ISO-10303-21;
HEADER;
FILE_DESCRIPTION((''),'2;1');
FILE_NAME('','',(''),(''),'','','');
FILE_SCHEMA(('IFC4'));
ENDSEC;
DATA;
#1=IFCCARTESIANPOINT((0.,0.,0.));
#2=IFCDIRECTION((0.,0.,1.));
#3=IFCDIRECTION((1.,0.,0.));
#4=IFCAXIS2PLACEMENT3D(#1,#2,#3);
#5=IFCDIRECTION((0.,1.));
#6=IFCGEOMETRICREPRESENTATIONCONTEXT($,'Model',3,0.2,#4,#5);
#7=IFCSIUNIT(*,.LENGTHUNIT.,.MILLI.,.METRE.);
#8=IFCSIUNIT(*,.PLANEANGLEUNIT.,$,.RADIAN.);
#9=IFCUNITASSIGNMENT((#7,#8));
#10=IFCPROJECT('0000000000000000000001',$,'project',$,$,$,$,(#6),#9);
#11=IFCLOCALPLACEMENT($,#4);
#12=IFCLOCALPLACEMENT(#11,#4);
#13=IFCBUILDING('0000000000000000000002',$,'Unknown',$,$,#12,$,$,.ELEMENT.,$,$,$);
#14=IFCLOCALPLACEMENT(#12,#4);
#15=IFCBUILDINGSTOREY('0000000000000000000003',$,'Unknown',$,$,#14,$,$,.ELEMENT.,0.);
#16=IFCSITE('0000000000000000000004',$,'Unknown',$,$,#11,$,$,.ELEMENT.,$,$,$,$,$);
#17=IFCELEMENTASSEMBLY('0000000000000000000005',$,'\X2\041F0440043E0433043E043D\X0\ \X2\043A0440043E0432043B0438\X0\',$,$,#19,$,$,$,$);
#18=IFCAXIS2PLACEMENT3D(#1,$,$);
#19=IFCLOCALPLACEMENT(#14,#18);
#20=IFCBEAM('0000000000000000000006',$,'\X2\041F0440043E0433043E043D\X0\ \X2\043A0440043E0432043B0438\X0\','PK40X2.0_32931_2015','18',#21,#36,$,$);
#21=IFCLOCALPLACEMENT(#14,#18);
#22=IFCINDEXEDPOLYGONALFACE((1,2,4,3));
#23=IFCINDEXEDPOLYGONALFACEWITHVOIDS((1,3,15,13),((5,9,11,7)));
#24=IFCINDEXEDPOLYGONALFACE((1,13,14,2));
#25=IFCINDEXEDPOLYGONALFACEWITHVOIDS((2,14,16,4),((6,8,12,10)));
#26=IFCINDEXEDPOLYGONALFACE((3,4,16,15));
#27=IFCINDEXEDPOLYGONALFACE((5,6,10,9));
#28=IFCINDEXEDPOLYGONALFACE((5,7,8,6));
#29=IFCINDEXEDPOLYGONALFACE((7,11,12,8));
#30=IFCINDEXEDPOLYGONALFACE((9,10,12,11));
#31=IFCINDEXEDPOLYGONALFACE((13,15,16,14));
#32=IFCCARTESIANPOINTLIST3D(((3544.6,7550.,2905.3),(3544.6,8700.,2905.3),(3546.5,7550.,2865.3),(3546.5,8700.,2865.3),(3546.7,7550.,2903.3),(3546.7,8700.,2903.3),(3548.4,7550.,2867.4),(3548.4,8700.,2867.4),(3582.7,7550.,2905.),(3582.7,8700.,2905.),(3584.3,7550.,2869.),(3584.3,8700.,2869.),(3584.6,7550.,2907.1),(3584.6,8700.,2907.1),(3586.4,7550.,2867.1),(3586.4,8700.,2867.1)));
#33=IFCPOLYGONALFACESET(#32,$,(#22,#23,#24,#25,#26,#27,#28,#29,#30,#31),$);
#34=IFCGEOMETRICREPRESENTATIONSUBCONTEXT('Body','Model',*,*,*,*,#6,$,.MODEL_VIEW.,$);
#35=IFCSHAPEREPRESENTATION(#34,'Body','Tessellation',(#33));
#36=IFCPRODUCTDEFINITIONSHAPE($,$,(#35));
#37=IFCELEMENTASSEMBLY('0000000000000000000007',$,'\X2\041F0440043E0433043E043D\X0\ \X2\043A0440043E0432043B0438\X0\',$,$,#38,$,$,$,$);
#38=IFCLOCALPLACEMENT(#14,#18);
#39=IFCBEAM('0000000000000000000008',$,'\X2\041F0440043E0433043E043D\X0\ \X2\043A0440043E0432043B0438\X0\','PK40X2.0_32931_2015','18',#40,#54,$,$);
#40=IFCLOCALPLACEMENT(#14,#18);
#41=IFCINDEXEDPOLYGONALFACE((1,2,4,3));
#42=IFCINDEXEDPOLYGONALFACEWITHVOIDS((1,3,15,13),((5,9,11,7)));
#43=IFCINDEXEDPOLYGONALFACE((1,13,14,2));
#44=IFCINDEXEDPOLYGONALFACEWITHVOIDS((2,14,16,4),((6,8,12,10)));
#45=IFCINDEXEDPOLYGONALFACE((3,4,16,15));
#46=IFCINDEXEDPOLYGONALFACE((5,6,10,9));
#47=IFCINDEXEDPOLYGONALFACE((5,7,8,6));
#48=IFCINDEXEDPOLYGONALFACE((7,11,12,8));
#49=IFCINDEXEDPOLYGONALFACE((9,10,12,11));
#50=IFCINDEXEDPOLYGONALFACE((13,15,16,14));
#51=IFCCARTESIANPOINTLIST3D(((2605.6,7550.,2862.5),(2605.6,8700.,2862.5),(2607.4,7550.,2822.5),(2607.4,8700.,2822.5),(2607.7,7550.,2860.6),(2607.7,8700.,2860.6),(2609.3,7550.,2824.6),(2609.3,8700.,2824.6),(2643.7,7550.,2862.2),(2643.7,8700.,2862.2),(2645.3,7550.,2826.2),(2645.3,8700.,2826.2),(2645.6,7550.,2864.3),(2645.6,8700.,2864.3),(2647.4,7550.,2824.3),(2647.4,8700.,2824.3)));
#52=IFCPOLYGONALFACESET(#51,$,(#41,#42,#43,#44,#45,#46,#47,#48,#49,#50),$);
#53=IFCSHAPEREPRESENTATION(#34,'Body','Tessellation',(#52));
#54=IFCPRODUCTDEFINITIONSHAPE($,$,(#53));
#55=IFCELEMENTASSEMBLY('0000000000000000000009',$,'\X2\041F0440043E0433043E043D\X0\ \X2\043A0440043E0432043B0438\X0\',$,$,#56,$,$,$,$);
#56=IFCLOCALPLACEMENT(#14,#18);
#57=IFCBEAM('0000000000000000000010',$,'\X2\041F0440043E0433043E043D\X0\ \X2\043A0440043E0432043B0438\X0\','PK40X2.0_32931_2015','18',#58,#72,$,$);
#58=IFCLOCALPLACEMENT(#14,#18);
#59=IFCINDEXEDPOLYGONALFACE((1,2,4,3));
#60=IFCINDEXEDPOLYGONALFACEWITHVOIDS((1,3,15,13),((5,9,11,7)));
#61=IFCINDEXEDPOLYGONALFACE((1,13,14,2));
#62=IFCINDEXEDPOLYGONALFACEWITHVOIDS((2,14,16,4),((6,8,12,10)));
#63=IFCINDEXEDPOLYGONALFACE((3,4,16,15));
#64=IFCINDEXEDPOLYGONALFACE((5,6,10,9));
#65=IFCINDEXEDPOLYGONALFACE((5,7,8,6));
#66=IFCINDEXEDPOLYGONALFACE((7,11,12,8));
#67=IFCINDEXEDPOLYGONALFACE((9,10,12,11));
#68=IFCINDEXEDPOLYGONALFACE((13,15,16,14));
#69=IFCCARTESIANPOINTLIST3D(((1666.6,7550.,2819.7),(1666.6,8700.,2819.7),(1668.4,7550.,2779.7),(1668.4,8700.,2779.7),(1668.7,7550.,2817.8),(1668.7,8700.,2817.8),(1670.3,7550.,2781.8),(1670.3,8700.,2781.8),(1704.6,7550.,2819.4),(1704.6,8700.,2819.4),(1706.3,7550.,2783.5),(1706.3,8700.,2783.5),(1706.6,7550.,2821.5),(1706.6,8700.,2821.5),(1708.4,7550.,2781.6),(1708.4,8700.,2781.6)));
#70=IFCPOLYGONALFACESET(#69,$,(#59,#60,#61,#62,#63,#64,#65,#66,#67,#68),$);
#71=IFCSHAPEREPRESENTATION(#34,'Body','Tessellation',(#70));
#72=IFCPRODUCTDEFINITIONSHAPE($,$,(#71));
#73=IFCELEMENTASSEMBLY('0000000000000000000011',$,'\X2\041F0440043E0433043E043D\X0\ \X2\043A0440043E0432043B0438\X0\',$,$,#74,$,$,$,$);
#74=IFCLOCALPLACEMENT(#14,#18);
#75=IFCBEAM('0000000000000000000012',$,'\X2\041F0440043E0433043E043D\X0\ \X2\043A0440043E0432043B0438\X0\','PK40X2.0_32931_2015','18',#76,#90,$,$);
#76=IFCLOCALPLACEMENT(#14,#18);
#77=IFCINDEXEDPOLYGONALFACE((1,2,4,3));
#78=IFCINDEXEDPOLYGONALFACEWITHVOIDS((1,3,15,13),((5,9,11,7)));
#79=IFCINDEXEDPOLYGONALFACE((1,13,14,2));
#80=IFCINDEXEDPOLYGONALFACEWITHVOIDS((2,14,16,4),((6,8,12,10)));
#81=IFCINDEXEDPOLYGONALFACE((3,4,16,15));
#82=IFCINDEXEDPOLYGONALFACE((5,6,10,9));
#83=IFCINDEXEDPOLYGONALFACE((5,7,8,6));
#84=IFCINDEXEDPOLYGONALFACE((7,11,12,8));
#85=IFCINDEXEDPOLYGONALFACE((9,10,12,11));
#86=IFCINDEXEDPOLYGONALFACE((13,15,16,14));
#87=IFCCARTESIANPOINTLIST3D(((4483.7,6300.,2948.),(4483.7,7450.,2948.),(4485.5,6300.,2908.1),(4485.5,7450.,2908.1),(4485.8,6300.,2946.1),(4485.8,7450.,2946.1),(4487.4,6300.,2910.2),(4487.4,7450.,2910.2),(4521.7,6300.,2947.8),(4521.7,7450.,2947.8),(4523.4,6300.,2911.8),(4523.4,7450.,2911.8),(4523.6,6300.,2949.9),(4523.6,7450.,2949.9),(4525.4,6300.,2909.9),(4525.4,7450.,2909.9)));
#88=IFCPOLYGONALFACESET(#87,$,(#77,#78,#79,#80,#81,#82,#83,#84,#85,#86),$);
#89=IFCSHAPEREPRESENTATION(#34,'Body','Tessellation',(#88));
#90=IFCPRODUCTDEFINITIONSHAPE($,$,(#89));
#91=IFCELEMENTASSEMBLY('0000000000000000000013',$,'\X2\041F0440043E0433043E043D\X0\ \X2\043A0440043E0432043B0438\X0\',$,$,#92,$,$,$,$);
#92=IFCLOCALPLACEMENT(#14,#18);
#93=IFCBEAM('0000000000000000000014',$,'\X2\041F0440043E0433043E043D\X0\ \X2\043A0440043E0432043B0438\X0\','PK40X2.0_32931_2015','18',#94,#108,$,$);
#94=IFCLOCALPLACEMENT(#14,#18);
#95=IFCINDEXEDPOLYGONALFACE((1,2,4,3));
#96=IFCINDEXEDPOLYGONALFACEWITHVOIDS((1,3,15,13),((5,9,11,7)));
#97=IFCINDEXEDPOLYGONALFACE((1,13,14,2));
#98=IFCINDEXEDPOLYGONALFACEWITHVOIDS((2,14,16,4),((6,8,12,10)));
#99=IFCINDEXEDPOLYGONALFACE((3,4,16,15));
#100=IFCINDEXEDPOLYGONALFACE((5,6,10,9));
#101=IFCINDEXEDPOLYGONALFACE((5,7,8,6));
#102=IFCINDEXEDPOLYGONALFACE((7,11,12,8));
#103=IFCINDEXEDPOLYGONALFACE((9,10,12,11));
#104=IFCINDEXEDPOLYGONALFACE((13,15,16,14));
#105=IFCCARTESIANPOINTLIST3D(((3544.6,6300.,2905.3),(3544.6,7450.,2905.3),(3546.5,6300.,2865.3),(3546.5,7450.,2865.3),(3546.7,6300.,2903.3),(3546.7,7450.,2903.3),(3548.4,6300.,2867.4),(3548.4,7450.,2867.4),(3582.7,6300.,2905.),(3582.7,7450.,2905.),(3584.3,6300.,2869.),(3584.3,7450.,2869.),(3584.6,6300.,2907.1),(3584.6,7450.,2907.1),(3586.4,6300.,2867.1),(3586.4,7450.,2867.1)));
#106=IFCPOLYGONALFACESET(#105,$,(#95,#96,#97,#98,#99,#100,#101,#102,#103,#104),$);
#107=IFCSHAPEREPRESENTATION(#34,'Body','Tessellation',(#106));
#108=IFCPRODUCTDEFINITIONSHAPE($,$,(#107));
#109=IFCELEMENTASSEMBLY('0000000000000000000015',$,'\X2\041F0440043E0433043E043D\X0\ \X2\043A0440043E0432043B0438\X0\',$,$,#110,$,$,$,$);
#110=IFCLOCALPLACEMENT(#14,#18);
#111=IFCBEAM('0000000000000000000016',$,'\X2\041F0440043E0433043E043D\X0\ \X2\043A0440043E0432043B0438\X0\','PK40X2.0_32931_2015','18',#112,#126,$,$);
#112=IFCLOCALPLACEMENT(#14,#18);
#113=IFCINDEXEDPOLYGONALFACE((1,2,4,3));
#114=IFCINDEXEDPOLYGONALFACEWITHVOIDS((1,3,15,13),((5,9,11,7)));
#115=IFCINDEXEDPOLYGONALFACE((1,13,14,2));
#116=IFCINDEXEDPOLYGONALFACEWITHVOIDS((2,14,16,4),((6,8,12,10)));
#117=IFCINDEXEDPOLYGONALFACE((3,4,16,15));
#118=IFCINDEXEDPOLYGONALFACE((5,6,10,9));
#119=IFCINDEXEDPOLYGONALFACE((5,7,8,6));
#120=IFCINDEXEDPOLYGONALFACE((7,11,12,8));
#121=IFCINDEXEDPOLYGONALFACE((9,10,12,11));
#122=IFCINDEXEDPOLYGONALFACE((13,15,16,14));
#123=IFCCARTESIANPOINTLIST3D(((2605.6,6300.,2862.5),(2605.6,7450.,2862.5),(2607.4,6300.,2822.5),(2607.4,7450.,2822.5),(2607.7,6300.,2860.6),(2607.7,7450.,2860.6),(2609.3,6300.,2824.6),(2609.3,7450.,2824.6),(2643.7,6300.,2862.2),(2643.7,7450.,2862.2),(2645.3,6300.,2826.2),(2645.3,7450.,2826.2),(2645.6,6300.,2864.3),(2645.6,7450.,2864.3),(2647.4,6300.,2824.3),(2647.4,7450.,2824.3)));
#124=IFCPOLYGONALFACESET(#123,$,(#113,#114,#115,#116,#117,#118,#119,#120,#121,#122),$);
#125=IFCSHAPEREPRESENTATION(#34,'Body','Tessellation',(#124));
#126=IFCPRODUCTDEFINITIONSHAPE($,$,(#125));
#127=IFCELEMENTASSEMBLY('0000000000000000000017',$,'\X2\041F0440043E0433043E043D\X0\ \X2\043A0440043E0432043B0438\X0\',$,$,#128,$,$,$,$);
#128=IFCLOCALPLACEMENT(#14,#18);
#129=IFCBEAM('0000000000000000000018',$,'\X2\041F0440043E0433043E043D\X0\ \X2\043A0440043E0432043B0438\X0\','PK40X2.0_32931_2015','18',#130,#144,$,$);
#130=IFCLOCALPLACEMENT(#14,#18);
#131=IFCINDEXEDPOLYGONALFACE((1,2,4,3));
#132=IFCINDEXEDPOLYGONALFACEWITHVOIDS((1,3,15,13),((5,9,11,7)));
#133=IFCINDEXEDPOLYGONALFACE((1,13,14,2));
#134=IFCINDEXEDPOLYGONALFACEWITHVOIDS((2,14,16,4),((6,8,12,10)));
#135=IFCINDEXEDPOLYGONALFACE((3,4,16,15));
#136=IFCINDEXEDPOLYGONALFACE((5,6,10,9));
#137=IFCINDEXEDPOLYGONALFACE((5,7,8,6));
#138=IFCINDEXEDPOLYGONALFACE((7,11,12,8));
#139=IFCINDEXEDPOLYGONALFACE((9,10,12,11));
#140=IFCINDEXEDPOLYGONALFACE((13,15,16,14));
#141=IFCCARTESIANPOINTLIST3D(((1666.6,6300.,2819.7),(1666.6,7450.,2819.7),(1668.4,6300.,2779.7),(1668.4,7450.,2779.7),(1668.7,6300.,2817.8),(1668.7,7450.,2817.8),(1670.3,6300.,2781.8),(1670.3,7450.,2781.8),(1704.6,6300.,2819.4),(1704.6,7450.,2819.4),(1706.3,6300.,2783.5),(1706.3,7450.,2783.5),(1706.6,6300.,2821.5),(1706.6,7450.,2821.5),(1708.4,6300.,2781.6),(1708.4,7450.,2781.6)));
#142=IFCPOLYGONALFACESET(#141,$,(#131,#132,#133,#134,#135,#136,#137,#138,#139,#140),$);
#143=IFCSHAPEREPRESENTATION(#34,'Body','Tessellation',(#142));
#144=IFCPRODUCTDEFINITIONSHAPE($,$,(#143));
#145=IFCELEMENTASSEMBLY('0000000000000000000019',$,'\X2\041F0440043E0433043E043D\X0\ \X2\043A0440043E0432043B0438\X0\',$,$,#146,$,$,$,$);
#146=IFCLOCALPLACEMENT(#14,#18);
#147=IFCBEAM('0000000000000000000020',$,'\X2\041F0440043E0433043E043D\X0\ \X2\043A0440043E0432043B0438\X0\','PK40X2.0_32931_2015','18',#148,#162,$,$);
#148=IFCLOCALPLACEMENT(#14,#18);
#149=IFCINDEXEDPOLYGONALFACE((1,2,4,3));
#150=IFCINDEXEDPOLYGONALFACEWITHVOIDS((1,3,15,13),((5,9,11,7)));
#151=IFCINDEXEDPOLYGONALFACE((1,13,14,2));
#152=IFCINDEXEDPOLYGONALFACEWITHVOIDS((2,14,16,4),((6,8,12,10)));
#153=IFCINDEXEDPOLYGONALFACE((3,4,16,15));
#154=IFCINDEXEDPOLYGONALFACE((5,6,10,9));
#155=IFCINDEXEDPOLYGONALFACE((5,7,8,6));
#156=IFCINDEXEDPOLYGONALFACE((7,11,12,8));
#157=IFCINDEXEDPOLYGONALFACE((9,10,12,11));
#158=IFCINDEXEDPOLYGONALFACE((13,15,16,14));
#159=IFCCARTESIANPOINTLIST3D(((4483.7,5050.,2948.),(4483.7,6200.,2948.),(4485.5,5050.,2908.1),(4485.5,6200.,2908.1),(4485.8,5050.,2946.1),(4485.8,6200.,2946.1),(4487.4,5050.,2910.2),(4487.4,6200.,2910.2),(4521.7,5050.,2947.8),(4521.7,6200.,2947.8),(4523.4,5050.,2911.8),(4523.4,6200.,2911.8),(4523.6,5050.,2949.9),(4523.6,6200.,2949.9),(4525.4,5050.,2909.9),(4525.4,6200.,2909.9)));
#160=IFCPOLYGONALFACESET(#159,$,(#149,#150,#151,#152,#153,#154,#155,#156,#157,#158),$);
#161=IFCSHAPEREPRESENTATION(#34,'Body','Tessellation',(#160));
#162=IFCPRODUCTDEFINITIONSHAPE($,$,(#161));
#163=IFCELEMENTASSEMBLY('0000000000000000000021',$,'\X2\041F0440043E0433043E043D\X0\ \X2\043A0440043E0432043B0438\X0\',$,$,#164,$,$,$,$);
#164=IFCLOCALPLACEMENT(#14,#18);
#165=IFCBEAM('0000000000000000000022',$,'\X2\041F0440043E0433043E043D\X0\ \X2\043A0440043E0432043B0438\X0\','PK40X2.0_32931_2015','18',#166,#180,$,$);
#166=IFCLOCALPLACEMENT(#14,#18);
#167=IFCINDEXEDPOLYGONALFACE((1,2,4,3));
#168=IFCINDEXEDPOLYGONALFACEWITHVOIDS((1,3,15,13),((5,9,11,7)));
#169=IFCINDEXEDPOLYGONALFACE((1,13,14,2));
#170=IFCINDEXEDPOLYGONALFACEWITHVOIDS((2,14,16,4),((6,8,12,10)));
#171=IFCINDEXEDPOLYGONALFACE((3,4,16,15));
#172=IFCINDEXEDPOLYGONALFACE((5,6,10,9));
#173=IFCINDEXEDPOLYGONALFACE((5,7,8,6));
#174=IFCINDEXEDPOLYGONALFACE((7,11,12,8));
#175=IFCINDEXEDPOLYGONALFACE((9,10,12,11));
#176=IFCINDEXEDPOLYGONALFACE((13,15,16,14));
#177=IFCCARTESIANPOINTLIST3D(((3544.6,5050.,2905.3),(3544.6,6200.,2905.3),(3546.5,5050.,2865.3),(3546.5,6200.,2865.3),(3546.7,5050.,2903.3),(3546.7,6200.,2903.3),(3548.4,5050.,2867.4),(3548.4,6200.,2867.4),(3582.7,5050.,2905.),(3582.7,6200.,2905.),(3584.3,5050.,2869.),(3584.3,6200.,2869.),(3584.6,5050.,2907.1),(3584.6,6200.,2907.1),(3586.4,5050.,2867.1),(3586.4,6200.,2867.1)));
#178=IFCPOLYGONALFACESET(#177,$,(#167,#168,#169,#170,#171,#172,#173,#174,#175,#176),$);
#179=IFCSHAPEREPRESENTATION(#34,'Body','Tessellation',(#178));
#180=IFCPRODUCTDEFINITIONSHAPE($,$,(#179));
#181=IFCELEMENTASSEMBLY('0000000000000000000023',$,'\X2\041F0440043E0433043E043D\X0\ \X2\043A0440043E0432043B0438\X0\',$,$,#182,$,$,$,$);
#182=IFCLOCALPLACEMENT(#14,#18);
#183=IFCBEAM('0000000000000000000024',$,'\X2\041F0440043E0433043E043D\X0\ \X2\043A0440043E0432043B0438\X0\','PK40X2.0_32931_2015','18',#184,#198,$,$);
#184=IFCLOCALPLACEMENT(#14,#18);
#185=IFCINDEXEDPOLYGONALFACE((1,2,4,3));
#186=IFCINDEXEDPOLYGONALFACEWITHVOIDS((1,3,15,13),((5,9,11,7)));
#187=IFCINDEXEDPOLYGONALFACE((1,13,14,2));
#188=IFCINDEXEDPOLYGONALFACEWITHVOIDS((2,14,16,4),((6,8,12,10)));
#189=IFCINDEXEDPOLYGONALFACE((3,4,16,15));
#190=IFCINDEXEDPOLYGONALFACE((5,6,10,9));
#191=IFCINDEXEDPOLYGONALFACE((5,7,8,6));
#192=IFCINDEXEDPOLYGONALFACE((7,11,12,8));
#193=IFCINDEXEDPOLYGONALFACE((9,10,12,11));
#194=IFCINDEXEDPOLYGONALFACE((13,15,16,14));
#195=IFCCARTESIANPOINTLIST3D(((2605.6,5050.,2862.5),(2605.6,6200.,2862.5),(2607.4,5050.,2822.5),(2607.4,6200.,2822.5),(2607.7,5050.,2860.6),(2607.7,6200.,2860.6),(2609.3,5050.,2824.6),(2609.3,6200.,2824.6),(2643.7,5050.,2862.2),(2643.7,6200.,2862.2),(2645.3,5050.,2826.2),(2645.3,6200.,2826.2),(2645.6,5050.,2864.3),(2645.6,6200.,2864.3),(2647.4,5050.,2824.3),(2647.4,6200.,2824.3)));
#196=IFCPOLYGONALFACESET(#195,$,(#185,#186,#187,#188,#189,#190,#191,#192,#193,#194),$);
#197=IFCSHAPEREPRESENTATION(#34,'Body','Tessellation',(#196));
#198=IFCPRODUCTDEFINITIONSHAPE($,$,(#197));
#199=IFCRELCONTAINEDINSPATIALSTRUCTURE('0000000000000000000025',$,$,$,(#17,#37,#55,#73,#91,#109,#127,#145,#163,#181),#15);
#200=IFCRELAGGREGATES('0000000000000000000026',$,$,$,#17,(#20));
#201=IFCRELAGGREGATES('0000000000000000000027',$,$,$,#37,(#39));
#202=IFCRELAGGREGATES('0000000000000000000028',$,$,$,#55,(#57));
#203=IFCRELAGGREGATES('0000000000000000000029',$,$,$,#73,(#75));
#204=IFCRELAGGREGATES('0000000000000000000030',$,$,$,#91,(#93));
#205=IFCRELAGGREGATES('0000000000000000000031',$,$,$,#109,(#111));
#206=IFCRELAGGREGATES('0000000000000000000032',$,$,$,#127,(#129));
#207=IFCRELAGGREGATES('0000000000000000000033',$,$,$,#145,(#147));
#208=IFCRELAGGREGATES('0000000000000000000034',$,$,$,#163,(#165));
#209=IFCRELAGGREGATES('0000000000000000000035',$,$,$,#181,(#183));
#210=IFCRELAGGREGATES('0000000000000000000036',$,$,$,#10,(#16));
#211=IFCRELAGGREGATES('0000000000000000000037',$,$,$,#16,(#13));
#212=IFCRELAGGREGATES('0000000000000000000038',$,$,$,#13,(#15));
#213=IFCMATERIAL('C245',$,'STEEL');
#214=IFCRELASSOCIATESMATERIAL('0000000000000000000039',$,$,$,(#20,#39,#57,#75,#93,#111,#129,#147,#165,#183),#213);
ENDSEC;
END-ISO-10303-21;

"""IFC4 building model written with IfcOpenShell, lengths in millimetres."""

from ifc_helpers import new_model, si_unit, direction, frame, origin_with_axes, place, context, subcontext, project, spatial, line, indexed_curve, outline, extrude, material, element, aggregate, save


model = new_model("IFC4")

# Units and contexts
model_context = context("Model", 3, precision=0.2, world=origin_with_axes(), true_north=direction((0.0, 1.0)))
body_context = subcontext(model_context, "Body", "Model", "MODEL_VIEW")
ifc_project = project(units=[si_unit("LENGTHUNIT", "METRE", prefix="MILLI"), si_unit("PLANEANGLEUNIT", "RADIAN")], contexts=[model_context])

# Site, building, storey
site_placement = place(None, origin_with_axes())
site = spatial("IfcSite", under=ifc_project, at=site_placement, Name="Unknown", CompositionType="ELEMENT")
building_placement = place(site_placement, origin_with_axes())
building = spatial("IfcBuilding", under=site, at=building_placement, Name="Unknown", CompositionType="ELEMENT")
storey_placement = place(building_placement, origin_with_axes())
storey = spatial("IfcBuildingStorey", under=building, at=storey_placement, Name="Unknown", CompositionType="ELEMENT", Elevation=0.0)

# Shared definitions
ifc_material_1 = material(Name="C245", Category="STEEL")

# Element assemblies, beams
assembly_1_placement = place(storey_placement, frame((3565.5, 8700.0, 2886.2), z_axis=(-0.998964, 0.0, -0.045508), x_axis=(0.0, -1.0, 0.0)))
assembly_1 = element("IfcElementAssembly", 1, at=assembly_1_placement, inside=storey, Name="Прогон кровли")
beam_1_placement = place(assembly_1_placement, origin_with_axes())
beam_1 = element("IfcBeam", 2, at=beam_1_placement, material=ifc_material_1, Name="Прогон кровли", Description="PK40X2.0_32931_2015", ObjectType="18", context=body_context, shape_type="SolidModel", body=[
    extrude(outline(indexed_curve([(-20.0, -20.0), (20.0, -20.0), (20.0, 20.0), (-20.0, 20.0)], segments=[line(1, 2, 3, 4, 1)]), holes=[indexed_curve([(-18.0, -18.0), (-18.0, 18.0), (18.0, 18.0), (18.0, -18.0)], segments=[line(1, 2, 3, 4, 1)])]), frame((0.0, 0.0, 0.0), z_axis=(-1.0, 0.0, 0.0), x_axis=(0.0, 0.0, 1.0)), (0.0, 0.0, -1.0), 1150.0),
])
aggregate(assembly_1, [beam_1])
assembly_2_placement = place(storey_placement, frame((2626.5, 8700.0, 2843.4), z_axis=(-0.998964, 0.0, -0.045508), x_axis=(0.0, -1.0, 0.0)))
assembly_2 = element("IfcElementAssembly", 3, at=assembly_2_placement, inside=storey, Name="Прогон кровли")
beam_2_placement = place(assembly_2_placement, origin_with_axes())
beam_2 = element("IfcBeam", 4, at=beam_2_placement, material=ifc_material_1, Name="Прогон кровли", Description="PK40X2.0_32931_2015", ObjectType="18", context=body_context, shape_type="SolidModel", body=[
    extrude(outline(indexed_curve([(-20.0, -20.0), (20.0, -20.0), (20.0, 20.0), (-20.0, 20.0)], segments=[line(1, 2, 3, 4, 1)]), holes=[indexed_curve([(-18.0, -18.0), (-18.0, 18.0), (18.0, 18.0), (18.0, -18.0)], segments=[line(1, 2, 3, 4, 1)])]), frame((0.0, 0.0, 0.0), z_axis=(-1.0, 0.0, 0.0), x_axis=(0.0, 0.0, 1.0)), (0.0, 0.0, -1.0), 1150.0),
])
aggregate(assembly_2, [beam_2])
assembly_3_placement = place(storey_placement, frame((1687.5, 8700.0, 2800.6), z_axis=(-0.998964, 0.0, -0.045508), x_axis=(0.0, -1.0, 0.0)))
assembly_3 = element("IfcElementAssembly", 5, at=assembly_3_placement, inside=storey, Name="Прогон кровли")
beam_3_placement = place(assembly_3_placement, origin_with_axes())
beam_3 = element("IfcBeam", 6, at=beam_3_placement, material=ifc_material_1, Name="Прогон кровли", Description="PK40X2.0_32931_2015", ObjectType="18", context=body_context, shape_type="SolidModel", body=[
    extrude(outline(indexed_curve([(-20.0, -20.0), (20.0, -20.0), (20.0, 20.0), (-20.0, 20.0)], segments=[line(1, 2, 3, 4, 1)]), holes=[indexed_curve([(-18.0, -18.0), (-18.0, 18.0), (18.0, 18.0), (18.0, -18.0)], segments=[line(1, 2, 3, 4, 1)])]), frame((0.0, 0.0, 0.0), z_axis=(-1.0, 0.0, 0.0), x_axis=(0.0, 0.0, 1.0)), (0.0, 0.0, -1.0), 1150.0),
])
aggregate(assembly_3, [beam_3])
assembly_4_placement = place(storey_placement, frame((4504.6, 7450.0, 2929.0), z_axis=(-0.998964, 0.0, -0.045508), x_axis=(0.0, -1.0, 0.0)))
assembly_4 = element("IfcElementAssembly", 7, at=assembly_4_placement, inside=storey, Name="Прогон кровли")
beam_4_placement = place(assembly_4_placement, origin_with_axes())
beam_4 = element("IfcBeam", 8, at=beam_4_placement, material=ifc_material_1, Name="Прогон кровли", Description="PK40X2.0_32931_2015", ObjectType="18", context=body_context, shape_type="SolidModel", body=[
    extrude(outline(indexed_curve([(-20.0, -20.0), (20.0, -20.0), (20.0, 20.0), (-20.0, 20.0)], segments=[line(1, 2, 3, 4, 1)]), holes=[indexed_curve([(-18.0, -18.0), (-18.0, 18.0), (18.0, 18.0), (18.0, -18.0)], segments=[line(1, 2, 3, 4, 1)])]), frame((0.0, 0.0, 0.0), z_axis=(-1.0, 0.0, 0.0), x_axis=(0.0, 0.0, 1.0)), (0.0, 0.0, -1.0), 1150.0),
])
aggregate(assembly_4, [beam_4])
assembly_5_placement = place(storey_placement, frame((3565.5, 7450.0, 2886.2), z_axis=(-0.998964, 0.0, -0.045508), x_axis=(0.0, -1.0, 0.0)))
assembly_5 = element("IfcElementAssembly", 9, at=assembly_5_placement, inside=storey, Name="Прогон кровли")
beam_5_placement = place(assembly_5_placement, origin_with_axes())
beam_5 = element("IfcBeam", 10, at=beam_5_placement, material=ifc_material_1, Name="Прогон кровли", Description="PK40X2.0_32931_2015", ObjectType="18", context=body_context, shape_type="SolidModel", body=[
    extrude(outline(indexed_curve([(-20.0, -20.0), (20.0, -20.0), (20.0, 20.0), (-20.0, 20.0)], segments=[line(1, 2, 3, 4, 1)]), holes=[indexed_curve([(-18.0, -18.0), (-18.0, 18.0), (18.0, 18.0), (18.0, -18.0)], segments=[line(1, 2, 3, 4, 1)])]), frame((0.0, 0.0, 0.0), z_axis=(-1.0, 0.0, 0.0), x_axis=(0.0, 0.0, 1.0)), (0.0, 0.0, -1.0), 1150.0),
])
aggregate(assembly_5, [beam_5])
assembly_6_placement = place(storey_placement, frame((2626.5, 7450.0, 2843.4), z_axis=(-0.998964, 0.0, -0.045508), x_axis=(0.0, -1.0, 0.0)))
assembly_6 = element("IfcElementAssembly", 11, at=assembly_6_placement, inside=storey, Name="Прогон кровли")
beam_6_placement = place(assembly_6_placement, origin_with_axes())
beam_6 = element("IfcBeam", 12, at=beam_6_placement, material=ifc_material_1, Name="Прогон кровли", Description="PK40X2.0_32931_2015", ObjectType="18", context=body_context, shape_type="SolidModel", body=[
    extrude(outline(indexed_curve([(-20.0, -20.0), (20.0, -20.0), (20.0, 20.0), (-20.0, 20.0)], segments=[line(1, 2, 3, 4, 1)]), holes=[indexed_curve([(-18.0, -18.0), (-18.0, 18.0), (18.0, 18.0), (18.0, -18.0)], segments=[line(1, 2, 3, 4, 1)])]), frame((0.0, 0.0, 0.0), z_axis=(-1.0, 0.0, 0.0), x_axis=(0.0, 0.0, 1.0)), (0.0, 0.0, -1.0), 1150.0),
])
aggregate(assembly_6, [beam_6])
assembly_7_placement = place(storey_placement, frame((1687.5, 7450.0, 2800.6), z_axis=(-0.998964, 0.0, -0.045508), x_axis=(0.0, -1.0, 0.0)))
assembly_7 = element("IfcElementAssembly", 13, at=assembly_7_placement, inside=storey, Name="Прогон кровли")
beam_7_placement = place(assembly_7_placement, origin_with_axes())
beam_7 = element("IfcBeam", 14, at=beam_7_placement, material=ifc_material_1, Name="Прогон кровли", Description="PK40X2.0_32931_2015", ObjectType="18", context=body_context, shape_type="SolidModel", body=[
    extrude(outline(indexed_curve([(-20.0, -20.0), (20.0, -20.0), (20.0, 20.0), (-20.0, 20.0)], segments=[line(1, 2, 3, 4, 1)]), holes=[indexed_curve([(-18.0, -18.0), (-18.0, 18.0), (18.0, 18.0), (18.0, -18.0)], segments=[line(1, 2, 3, 4, 1)])]), frame((0.0, 0.0, 0.0), z_axis=(-1.0, 0.0, 0.0), x_axis=(0.0, 0.0, 1.0)), (0.0, 0.0, -1.0), 1150.0),
])
aggregate(assembly_7, [beam_7])
assembly_8_placement = place(storey_placement, frame((4504.6, 6200.0, 2929.0), z_axis=(-0.998964, 0.0, -0.045508), x_axis=(0.0, -1.0, 0.0)))
assembly_8 = element("IfcElementAssembly", 15, at=assembly_8_placement, inside=storey, Name="Прогон кровли")
beam_8_placement = place(assembly_8_placement, origin_with_axes())
beam_8 = element("IfcBeam", 16, at=beam_8_placement, material=ifc_material_1, Name="Прогон кровли", Description="PK40X2.0_32931_2015", ObjectType="18", context=body_context, shape_type="SolidModel", body=[
    extrude(outline(indexed_curve([(-20.0, -20.0), (20.0, -20.0), (20.0, 20.0), (-20.0, 20.0)], segments=[line(1, 2, 3, 4, 1)]), holes=[indexed_curve([(-18.0, -18.0), (-18.0, 18.0), (18.0, 18.0), (18.0, -18.0)], segments=[line(1, 2, 3, 4, 1)])]), frame((0.0, 0.0, 0.0), z_axis=(-1.0, 0.0, 0.0), x_axis=(0.0, 0.0, 1.0)), (0.0, 0.0, -1.0), 1150.0),
])
aggregate(assembly_8, [beam_8])
assembly_9_placement = place(storey_placement, frame((3565.5, 6200.0, 2886.2), z_axis=(-0.998964, 0.0, -0.045508), x_axis=(0.0, -1.0, 0.0)))
assembly_9 = element("IfcElementAssembly", 17, at=assembly_9_placement, inside=storey, Name="Прогон кровли")
beam_9_placement = place(assembly_9_placement, origin_with_axes())
beam_9 = element("IfcBeam", 18, at=beam_9_placement, material=ifc_material_1, Name="Прогон кровли", Description="PK40X2.0_32931_2015", ObjectType="18", context=body_context, shape_type="SolidModel", body=[
    extrude(outline(indexed_curve([(-20.0, -20.0), (20.0, -20.0), (20.0, 20.0), (-20.0, 20.0)], segments=[line(1, 2, 3, 4, 1)]), holes=[indexed_curve([(-18.0, -18.0), (-18.0, 18.0), (18.0, 18.0), (18.0, -18.0)], segments=[line(1, 2, 3, 4, 1)])]), frame((0.0, 0.0, 0.0), z_axis=(-1.0, 0.0, 0.0), x_axis=(0.0, 0.0, 1.0)), (0.0, 0.0, -1.0), 1150.0),
])
aggregate(assembly_9, [beam_9])
assembly_10_placement = place(storey_placement, frame((2626.5, 6200.0, 2843.4), z_axis=(-0.998964, 0.0, -0.045508), x_axis=(0.0, -1.0, 0.0)))
assembly_10 = element("IfcElementAssembly", 19, at=assembly_10_placement, inside=storey, Name="Прогон кровли")
beam_10_placement = place(assembly_10_placement, origin_with_axes())
beam_10 = element("IfcBeam", 20, at=beam_10_placement, material=ifc_material_1, Name="Прогон кровли", Description="PK40X2.0_32931_2015", ObjectType="18", context=body_context, shape_type="SolidModel", body=[
    extrude(outline(indexed_curve([(-20.0, -20.0), (20.0, -20.0), (20.0, 20.0), (-20.0, 20.0)], segments=[line(1, 2, 3, 4, 1)]), holes=[indexed_curve([(-18.0, -18.0), (-18.0, 18.0), (18.0, 18.0), (18.0, -18.0)], segments=[line(1, 2, 3, 4, 1)])]), frame((0.0, 0.0, 0.0), z_axis=(-1.0, 0.0, 0.0), x_axis=(0.0, 0.0, 1.0)), (0.0, 0.0, -1.0), 1150.0),
])
aggregate(assembly_10, [beam_10])

save(model, "model.ifc")
